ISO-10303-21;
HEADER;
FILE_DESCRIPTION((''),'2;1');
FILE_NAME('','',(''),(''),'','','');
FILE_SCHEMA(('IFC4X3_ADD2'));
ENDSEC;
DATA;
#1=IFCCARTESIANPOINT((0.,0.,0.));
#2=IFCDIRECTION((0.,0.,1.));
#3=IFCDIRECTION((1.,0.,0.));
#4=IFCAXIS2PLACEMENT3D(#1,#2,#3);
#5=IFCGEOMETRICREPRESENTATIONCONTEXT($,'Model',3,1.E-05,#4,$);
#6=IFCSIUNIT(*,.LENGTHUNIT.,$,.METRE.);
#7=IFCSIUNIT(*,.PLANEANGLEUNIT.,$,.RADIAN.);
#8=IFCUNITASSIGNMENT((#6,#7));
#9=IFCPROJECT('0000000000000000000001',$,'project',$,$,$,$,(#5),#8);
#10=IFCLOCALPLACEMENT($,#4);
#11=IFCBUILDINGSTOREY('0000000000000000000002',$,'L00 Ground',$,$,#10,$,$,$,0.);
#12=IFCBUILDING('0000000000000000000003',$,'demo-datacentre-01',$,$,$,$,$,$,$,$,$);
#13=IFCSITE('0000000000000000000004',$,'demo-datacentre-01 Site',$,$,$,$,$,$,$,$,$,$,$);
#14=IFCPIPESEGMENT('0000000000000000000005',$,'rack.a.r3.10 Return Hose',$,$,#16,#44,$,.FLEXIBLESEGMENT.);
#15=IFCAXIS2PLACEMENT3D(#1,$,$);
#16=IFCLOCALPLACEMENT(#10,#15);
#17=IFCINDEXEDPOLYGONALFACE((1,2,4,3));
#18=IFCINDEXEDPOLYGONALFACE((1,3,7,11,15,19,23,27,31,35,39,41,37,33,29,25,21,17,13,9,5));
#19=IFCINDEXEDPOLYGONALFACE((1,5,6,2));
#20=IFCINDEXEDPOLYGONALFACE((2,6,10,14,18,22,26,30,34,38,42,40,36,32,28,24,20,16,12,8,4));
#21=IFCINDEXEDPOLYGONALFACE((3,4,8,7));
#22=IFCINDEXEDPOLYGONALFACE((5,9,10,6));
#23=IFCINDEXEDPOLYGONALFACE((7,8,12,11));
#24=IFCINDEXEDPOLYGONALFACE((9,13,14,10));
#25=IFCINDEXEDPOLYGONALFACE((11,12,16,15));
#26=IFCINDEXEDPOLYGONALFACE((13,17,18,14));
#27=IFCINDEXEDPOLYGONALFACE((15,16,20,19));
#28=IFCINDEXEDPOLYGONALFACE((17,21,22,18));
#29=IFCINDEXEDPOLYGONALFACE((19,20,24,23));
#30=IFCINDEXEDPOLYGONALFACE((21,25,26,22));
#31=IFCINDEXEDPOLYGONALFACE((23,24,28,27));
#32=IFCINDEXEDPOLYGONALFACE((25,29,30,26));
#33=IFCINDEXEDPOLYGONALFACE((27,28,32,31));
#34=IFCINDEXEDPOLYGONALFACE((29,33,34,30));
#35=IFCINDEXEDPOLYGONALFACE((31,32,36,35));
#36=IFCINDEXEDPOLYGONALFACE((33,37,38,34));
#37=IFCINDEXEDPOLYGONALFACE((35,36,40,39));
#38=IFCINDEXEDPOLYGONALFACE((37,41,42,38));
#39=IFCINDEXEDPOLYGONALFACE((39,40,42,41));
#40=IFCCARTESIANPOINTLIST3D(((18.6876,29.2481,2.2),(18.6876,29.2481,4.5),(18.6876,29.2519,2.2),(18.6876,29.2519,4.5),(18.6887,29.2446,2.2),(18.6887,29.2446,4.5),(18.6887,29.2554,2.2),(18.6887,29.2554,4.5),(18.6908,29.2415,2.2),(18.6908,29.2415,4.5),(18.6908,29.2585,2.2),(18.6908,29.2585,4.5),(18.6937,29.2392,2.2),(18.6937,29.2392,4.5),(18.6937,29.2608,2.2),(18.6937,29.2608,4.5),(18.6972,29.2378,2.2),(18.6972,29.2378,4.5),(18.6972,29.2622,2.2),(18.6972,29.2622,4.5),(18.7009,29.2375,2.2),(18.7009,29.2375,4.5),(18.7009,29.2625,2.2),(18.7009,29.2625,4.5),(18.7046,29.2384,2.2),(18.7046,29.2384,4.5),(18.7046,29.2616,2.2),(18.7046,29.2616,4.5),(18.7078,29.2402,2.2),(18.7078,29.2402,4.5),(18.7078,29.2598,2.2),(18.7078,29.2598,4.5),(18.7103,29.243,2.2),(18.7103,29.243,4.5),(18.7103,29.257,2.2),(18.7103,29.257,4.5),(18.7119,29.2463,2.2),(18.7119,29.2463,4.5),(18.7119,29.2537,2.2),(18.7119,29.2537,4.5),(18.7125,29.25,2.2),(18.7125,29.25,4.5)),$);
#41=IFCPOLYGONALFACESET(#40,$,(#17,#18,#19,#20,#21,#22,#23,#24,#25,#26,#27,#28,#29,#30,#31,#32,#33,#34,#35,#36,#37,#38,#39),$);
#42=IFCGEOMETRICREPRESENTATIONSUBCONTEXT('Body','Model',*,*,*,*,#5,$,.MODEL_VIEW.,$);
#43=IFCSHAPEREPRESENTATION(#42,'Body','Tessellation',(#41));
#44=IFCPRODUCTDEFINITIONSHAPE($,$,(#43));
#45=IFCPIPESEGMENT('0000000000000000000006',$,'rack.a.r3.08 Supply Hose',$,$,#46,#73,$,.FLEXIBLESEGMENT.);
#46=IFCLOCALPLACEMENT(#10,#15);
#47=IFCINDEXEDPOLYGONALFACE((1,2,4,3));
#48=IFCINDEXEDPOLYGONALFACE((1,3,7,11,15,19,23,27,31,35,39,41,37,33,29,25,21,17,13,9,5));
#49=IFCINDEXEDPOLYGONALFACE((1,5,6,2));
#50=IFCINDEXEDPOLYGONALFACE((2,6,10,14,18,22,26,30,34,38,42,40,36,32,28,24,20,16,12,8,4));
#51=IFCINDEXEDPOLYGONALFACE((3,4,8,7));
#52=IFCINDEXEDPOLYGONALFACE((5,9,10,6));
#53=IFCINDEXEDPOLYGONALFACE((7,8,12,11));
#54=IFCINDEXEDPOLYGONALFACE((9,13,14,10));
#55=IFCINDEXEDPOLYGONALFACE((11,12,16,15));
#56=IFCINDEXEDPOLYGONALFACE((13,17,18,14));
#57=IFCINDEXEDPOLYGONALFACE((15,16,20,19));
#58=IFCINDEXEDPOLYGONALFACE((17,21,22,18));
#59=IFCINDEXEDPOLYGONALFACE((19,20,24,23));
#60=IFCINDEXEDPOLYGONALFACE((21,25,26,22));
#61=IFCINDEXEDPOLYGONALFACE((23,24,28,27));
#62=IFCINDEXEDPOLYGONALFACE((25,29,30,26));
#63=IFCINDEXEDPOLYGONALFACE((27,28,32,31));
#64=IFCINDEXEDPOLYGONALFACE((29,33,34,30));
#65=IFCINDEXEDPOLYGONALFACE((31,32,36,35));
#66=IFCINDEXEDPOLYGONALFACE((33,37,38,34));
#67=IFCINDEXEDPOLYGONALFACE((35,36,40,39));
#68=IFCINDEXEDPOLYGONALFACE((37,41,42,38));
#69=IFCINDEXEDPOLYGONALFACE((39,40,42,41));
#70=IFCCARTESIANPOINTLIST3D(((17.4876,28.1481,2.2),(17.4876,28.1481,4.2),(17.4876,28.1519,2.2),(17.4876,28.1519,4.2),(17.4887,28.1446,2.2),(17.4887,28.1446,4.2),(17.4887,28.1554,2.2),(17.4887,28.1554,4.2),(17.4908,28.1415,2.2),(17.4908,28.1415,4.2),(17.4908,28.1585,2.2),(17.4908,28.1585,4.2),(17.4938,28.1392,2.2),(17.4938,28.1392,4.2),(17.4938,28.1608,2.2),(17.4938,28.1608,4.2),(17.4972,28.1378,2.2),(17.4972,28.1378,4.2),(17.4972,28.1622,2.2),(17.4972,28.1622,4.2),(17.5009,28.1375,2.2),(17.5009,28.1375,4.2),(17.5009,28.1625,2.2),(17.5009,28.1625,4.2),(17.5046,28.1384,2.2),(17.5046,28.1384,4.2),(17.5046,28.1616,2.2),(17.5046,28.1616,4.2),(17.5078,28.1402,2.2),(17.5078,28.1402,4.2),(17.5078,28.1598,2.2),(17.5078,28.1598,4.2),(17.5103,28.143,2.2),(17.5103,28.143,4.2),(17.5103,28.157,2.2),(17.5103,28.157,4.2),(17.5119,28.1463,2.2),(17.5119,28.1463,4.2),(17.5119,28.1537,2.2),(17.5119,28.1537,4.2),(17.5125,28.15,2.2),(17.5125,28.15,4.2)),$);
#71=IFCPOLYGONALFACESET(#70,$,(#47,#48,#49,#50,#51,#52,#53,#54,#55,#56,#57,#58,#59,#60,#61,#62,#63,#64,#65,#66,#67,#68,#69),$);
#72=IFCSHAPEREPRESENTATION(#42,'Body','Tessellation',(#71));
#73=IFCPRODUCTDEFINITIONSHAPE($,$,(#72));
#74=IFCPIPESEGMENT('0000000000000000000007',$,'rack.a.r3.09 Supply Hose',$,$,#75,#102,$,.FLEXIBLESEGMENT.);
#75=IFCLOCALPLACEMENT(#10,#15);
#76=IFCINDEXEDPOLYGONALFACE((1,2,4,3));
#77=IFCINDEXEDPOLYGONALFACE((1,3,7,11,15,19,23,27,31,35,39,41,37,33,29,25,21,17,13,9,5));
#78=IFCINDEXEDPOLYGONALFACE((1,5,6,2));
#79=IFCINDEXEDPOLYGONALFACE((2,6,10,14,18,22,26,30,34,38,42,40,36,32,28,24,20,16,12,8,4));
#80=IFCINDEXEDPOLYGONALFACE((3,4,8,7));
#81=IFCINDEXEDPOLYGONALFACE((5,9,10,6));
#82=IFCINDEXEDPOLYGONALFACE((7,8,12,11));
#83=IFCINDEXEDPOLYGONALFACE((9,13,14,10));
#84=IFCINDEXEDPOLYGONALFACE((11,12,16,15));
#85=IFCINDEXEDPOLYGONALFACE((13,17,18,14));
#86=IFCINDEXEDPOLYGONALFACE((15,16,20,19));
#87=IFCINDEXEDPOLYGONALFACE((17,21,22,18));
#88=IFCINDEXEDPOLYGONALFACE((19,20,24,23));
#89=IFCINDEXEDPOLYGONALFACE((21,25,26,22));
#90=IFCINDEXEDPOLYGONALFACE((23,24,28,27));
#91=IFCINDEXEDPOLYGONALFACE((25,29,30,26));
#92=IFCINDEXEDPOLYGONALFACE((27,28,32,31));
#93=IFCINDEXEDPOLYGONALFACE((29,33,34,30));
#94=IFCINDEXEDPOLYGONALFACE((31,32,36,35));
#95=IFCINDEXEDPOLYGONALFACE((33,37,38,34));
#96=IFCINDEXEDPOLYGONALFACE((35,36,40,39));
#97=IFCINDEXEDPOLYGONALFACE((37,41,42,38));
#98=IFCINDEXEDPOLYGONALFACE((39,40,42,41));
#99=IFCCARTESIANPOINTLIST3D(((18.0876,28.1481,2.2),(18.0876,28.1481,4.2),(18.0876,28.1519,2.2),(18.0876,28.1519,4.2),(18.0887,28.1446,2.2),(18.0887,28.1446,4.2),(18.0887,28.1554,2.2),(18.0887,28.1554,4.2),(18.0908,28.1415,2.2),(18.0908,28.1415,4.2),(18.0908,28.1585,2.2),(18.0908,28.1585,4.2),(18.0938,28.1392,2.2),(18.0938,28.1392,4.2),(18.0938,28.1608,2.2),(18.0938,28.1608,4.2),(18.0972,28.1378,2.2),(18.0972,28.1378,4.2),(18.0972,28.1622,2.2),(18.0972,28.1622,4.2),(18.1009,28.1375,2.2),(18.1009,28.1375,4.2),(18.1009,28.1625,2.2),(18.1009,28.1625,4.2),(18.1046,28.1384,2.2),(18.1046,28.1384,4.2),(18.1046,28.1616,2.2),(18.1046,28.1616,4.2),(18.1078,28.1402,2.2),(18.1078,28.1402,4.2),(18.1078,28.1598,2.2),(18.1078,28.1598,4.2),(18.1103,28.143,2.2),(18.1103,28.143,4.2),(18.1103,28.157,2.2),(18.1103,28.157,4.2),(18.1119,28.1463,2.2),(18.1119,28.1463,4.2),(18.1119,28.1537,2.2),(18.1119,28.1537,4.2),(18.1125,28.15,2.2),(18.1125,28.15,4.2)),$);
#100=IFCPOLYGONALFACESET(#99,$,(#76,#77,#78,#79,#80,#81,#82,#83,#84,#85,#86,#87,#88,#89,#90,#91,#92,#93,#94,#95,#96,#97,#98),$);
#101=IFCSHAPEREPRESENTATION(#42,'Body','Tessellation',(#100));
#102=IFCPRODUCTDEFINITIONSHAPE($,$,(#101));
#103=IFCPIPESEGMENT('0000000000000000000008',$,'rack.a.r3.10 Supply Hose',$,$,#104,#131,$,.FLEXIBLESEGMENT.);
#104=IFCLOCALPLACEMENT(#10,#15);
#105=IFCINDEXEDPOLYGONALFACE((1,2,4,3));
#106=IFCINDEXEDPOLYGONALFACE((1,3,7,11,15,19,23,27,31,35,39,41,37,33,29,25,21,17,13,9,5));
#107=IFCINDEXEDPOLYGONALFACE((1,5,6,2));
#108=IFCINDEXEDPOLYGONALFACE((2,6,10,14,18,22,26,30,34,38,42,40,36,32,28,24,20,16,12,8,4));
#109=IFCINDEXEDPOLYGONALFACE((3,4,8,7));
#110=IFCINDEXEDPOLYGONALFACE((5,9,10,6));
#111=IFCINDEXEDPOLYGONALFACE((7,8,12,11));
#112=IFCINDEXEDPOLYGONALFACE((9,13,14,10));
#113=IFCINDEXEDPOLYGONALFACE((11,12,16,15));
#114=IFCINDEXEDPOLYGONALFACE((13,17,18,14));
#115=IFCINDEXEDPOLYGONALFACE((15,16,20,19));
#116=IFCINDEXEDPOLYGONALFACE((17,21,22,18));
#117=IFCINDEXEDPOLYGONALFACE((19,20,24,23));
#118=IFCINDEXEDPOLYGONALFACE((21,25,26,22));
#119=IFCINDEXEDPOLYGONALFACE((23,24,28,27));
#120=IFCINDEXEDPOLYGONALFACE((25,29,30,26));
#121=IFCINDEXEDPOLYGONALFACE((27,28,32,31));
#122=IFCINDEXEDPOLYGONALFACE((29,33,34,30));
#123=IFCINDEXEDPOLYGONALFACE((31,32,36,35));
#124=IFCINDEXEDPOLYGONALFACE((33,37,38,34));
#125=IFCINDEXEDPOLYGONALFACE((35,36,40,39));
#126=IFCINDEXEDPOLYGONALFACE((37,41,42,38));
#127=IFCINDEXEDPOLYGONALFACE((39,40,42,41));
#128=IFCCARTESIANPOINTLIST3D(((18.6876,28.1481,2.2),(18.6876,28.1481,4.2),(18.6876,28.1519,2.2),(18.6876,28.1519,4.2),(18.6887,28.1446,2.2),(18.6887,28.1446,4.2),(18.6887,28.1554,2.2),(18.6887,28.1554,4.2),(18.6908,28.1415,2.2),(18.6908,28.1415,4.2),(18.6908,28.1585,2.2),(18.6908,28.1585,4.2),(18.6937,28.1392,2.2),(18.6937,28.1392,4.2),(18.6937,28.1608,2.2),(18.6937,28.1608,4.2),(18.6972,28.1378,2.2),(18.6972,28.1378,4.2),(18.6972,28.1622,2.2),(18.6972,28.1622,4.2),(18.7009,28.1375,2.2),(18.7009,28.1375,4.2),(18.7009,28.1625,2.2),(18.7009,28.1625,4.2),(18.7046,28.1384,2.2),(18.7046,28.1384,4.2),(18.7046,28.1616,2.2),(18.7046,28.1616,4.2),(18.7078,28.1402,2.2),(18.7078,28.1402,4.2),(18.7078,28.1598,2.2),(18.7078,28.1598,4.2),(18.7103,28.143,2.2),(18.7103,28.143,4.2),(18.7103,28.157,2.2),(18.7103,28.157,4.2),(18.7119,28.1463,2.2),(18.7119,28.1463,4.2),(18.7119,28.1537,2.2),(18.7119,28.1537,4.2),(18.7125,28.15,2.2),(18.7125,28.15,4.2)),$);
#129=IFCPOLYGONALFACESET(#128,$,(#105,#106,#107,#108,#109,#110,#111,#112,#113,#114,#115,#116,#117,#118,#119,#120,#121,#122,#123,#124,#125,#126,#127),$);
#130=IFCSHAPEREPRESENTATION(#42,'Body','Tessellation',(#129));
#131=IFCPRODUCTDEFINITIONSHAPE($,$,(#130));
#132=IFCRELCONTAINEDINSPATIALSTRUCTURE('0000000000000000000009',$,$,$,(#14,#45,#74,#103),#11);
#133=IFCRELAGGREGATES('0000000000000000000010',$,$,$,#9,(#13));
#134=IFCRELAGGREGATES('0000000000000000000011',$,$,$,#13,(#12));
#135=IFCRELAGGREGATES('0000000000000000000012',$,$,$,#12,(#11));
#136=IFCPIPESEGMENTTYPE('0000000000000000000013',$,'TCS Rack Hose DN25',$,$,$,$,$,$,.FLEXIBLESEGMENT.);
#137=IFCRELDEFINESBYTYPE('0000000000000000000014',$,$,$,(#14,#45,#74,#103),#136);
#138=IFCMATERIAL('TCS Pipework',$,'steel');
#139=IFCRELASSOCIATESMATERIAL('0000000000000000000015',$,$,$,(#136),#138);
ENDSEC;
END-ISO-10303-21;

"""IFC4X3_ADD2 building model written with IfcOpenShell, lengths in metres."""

from ifc_helpers import new_model, si_unit, frame, origin_with_axes, place, context, subcontext, project, spatial, circle, extrude, material, type_object, element, save


model = new_model("IFC4X3_ADD2")

# Units and contexts
model_context = context("Model", 3, precision=1e-05, world=origin_with_axes())
body_context = subcontext(model_context, "Body", "Model", "MODEL_VIEW")
ifc_project = project(units=[si_unit("LENGTHUNIT", "METRE"), si_unit("PLANEANGLEUNIT", "RADIAN")], contexts=[model_context])

# Site, building, storey
site = spatial("IfcSite", under=ifc_project, Name="demo-datacentre-01 Site")
building = spatial("IfcBuilding", under=site, Name="demo-datacentre-01")
storey_placement = place(None, origin_with_axes())
storey = spatial("IfcBuildingStorey", under=building, at=storey_placement, Name="L00 Ground", Elevation=0.0)

# Shared definitions
ifc_material = material(Name="TCS Pipework", Category="steel")

# Pipe segments
pipe_segment_type_1 = type_object("IfcPipeSegmentType", Name="TCS Rack Hose DN25", PredefinedType="FLEXIBLESEGMENT", material=ifc_material)
for number, where, z_axis, x_axis, name in (
    (1, (18.7, 29.25, 4.5), (0.0, 0.0, -1.0), (1.0, 0.0, 0.0), "rack.a.r3.10 Return Hose"),
):
    element("IfcPipeSegment", number, at=place(storey_placement, frame(where, z_axis=z_axis, x_axis=x_axis)), inside=storey, type_object=pipe_segment_type_1, Name=name, PredefinedType="FLEXIBLESEGMENT", context=body_context, shape_type="SweptSolid", body=[
        extrude(circle(Radius=0.0125), origin_with_axes(), (0.0, 0.0, 1.0), 2.3),
    ])
for number, where, z_axis, x_axis, name in (
    (2, (17.5, 28.15, 4.2), (0.0, 0.0, -1.0), (1.0, 0.0, 0.0), "rack.a.r3.08 Supply Hose"),
    (3, (18.1, 28.15, 4.2), (0.0, 0.0, -1.0), (1.0, 0.0, 0.0), "rack.a.r3.09 Supply Hose"),
    (4, (18.7, 28.15, 4.2), (0.0, 0.0, -1.0), (1.0, 0.0, 0.0), "rack.a.r3.10 Supply Hose"),
):
    element("IfcPipeSegment", number, at=place(storey_placement, frame(where, z_axis=z_axis, x_axis=x_axis)), inside=storey, type_object=pipe_segment_type_1, Name=name, PredefinedType="FLEXIBLESEGMENT", context=body_context, shape_type="SweptSolid", body=[
        extrude(circle(Radius=0.0125), origin_with_axes(), (0.0, 0.0, 1.0), 2.0),
    ])

save(model, "model.ifc")
